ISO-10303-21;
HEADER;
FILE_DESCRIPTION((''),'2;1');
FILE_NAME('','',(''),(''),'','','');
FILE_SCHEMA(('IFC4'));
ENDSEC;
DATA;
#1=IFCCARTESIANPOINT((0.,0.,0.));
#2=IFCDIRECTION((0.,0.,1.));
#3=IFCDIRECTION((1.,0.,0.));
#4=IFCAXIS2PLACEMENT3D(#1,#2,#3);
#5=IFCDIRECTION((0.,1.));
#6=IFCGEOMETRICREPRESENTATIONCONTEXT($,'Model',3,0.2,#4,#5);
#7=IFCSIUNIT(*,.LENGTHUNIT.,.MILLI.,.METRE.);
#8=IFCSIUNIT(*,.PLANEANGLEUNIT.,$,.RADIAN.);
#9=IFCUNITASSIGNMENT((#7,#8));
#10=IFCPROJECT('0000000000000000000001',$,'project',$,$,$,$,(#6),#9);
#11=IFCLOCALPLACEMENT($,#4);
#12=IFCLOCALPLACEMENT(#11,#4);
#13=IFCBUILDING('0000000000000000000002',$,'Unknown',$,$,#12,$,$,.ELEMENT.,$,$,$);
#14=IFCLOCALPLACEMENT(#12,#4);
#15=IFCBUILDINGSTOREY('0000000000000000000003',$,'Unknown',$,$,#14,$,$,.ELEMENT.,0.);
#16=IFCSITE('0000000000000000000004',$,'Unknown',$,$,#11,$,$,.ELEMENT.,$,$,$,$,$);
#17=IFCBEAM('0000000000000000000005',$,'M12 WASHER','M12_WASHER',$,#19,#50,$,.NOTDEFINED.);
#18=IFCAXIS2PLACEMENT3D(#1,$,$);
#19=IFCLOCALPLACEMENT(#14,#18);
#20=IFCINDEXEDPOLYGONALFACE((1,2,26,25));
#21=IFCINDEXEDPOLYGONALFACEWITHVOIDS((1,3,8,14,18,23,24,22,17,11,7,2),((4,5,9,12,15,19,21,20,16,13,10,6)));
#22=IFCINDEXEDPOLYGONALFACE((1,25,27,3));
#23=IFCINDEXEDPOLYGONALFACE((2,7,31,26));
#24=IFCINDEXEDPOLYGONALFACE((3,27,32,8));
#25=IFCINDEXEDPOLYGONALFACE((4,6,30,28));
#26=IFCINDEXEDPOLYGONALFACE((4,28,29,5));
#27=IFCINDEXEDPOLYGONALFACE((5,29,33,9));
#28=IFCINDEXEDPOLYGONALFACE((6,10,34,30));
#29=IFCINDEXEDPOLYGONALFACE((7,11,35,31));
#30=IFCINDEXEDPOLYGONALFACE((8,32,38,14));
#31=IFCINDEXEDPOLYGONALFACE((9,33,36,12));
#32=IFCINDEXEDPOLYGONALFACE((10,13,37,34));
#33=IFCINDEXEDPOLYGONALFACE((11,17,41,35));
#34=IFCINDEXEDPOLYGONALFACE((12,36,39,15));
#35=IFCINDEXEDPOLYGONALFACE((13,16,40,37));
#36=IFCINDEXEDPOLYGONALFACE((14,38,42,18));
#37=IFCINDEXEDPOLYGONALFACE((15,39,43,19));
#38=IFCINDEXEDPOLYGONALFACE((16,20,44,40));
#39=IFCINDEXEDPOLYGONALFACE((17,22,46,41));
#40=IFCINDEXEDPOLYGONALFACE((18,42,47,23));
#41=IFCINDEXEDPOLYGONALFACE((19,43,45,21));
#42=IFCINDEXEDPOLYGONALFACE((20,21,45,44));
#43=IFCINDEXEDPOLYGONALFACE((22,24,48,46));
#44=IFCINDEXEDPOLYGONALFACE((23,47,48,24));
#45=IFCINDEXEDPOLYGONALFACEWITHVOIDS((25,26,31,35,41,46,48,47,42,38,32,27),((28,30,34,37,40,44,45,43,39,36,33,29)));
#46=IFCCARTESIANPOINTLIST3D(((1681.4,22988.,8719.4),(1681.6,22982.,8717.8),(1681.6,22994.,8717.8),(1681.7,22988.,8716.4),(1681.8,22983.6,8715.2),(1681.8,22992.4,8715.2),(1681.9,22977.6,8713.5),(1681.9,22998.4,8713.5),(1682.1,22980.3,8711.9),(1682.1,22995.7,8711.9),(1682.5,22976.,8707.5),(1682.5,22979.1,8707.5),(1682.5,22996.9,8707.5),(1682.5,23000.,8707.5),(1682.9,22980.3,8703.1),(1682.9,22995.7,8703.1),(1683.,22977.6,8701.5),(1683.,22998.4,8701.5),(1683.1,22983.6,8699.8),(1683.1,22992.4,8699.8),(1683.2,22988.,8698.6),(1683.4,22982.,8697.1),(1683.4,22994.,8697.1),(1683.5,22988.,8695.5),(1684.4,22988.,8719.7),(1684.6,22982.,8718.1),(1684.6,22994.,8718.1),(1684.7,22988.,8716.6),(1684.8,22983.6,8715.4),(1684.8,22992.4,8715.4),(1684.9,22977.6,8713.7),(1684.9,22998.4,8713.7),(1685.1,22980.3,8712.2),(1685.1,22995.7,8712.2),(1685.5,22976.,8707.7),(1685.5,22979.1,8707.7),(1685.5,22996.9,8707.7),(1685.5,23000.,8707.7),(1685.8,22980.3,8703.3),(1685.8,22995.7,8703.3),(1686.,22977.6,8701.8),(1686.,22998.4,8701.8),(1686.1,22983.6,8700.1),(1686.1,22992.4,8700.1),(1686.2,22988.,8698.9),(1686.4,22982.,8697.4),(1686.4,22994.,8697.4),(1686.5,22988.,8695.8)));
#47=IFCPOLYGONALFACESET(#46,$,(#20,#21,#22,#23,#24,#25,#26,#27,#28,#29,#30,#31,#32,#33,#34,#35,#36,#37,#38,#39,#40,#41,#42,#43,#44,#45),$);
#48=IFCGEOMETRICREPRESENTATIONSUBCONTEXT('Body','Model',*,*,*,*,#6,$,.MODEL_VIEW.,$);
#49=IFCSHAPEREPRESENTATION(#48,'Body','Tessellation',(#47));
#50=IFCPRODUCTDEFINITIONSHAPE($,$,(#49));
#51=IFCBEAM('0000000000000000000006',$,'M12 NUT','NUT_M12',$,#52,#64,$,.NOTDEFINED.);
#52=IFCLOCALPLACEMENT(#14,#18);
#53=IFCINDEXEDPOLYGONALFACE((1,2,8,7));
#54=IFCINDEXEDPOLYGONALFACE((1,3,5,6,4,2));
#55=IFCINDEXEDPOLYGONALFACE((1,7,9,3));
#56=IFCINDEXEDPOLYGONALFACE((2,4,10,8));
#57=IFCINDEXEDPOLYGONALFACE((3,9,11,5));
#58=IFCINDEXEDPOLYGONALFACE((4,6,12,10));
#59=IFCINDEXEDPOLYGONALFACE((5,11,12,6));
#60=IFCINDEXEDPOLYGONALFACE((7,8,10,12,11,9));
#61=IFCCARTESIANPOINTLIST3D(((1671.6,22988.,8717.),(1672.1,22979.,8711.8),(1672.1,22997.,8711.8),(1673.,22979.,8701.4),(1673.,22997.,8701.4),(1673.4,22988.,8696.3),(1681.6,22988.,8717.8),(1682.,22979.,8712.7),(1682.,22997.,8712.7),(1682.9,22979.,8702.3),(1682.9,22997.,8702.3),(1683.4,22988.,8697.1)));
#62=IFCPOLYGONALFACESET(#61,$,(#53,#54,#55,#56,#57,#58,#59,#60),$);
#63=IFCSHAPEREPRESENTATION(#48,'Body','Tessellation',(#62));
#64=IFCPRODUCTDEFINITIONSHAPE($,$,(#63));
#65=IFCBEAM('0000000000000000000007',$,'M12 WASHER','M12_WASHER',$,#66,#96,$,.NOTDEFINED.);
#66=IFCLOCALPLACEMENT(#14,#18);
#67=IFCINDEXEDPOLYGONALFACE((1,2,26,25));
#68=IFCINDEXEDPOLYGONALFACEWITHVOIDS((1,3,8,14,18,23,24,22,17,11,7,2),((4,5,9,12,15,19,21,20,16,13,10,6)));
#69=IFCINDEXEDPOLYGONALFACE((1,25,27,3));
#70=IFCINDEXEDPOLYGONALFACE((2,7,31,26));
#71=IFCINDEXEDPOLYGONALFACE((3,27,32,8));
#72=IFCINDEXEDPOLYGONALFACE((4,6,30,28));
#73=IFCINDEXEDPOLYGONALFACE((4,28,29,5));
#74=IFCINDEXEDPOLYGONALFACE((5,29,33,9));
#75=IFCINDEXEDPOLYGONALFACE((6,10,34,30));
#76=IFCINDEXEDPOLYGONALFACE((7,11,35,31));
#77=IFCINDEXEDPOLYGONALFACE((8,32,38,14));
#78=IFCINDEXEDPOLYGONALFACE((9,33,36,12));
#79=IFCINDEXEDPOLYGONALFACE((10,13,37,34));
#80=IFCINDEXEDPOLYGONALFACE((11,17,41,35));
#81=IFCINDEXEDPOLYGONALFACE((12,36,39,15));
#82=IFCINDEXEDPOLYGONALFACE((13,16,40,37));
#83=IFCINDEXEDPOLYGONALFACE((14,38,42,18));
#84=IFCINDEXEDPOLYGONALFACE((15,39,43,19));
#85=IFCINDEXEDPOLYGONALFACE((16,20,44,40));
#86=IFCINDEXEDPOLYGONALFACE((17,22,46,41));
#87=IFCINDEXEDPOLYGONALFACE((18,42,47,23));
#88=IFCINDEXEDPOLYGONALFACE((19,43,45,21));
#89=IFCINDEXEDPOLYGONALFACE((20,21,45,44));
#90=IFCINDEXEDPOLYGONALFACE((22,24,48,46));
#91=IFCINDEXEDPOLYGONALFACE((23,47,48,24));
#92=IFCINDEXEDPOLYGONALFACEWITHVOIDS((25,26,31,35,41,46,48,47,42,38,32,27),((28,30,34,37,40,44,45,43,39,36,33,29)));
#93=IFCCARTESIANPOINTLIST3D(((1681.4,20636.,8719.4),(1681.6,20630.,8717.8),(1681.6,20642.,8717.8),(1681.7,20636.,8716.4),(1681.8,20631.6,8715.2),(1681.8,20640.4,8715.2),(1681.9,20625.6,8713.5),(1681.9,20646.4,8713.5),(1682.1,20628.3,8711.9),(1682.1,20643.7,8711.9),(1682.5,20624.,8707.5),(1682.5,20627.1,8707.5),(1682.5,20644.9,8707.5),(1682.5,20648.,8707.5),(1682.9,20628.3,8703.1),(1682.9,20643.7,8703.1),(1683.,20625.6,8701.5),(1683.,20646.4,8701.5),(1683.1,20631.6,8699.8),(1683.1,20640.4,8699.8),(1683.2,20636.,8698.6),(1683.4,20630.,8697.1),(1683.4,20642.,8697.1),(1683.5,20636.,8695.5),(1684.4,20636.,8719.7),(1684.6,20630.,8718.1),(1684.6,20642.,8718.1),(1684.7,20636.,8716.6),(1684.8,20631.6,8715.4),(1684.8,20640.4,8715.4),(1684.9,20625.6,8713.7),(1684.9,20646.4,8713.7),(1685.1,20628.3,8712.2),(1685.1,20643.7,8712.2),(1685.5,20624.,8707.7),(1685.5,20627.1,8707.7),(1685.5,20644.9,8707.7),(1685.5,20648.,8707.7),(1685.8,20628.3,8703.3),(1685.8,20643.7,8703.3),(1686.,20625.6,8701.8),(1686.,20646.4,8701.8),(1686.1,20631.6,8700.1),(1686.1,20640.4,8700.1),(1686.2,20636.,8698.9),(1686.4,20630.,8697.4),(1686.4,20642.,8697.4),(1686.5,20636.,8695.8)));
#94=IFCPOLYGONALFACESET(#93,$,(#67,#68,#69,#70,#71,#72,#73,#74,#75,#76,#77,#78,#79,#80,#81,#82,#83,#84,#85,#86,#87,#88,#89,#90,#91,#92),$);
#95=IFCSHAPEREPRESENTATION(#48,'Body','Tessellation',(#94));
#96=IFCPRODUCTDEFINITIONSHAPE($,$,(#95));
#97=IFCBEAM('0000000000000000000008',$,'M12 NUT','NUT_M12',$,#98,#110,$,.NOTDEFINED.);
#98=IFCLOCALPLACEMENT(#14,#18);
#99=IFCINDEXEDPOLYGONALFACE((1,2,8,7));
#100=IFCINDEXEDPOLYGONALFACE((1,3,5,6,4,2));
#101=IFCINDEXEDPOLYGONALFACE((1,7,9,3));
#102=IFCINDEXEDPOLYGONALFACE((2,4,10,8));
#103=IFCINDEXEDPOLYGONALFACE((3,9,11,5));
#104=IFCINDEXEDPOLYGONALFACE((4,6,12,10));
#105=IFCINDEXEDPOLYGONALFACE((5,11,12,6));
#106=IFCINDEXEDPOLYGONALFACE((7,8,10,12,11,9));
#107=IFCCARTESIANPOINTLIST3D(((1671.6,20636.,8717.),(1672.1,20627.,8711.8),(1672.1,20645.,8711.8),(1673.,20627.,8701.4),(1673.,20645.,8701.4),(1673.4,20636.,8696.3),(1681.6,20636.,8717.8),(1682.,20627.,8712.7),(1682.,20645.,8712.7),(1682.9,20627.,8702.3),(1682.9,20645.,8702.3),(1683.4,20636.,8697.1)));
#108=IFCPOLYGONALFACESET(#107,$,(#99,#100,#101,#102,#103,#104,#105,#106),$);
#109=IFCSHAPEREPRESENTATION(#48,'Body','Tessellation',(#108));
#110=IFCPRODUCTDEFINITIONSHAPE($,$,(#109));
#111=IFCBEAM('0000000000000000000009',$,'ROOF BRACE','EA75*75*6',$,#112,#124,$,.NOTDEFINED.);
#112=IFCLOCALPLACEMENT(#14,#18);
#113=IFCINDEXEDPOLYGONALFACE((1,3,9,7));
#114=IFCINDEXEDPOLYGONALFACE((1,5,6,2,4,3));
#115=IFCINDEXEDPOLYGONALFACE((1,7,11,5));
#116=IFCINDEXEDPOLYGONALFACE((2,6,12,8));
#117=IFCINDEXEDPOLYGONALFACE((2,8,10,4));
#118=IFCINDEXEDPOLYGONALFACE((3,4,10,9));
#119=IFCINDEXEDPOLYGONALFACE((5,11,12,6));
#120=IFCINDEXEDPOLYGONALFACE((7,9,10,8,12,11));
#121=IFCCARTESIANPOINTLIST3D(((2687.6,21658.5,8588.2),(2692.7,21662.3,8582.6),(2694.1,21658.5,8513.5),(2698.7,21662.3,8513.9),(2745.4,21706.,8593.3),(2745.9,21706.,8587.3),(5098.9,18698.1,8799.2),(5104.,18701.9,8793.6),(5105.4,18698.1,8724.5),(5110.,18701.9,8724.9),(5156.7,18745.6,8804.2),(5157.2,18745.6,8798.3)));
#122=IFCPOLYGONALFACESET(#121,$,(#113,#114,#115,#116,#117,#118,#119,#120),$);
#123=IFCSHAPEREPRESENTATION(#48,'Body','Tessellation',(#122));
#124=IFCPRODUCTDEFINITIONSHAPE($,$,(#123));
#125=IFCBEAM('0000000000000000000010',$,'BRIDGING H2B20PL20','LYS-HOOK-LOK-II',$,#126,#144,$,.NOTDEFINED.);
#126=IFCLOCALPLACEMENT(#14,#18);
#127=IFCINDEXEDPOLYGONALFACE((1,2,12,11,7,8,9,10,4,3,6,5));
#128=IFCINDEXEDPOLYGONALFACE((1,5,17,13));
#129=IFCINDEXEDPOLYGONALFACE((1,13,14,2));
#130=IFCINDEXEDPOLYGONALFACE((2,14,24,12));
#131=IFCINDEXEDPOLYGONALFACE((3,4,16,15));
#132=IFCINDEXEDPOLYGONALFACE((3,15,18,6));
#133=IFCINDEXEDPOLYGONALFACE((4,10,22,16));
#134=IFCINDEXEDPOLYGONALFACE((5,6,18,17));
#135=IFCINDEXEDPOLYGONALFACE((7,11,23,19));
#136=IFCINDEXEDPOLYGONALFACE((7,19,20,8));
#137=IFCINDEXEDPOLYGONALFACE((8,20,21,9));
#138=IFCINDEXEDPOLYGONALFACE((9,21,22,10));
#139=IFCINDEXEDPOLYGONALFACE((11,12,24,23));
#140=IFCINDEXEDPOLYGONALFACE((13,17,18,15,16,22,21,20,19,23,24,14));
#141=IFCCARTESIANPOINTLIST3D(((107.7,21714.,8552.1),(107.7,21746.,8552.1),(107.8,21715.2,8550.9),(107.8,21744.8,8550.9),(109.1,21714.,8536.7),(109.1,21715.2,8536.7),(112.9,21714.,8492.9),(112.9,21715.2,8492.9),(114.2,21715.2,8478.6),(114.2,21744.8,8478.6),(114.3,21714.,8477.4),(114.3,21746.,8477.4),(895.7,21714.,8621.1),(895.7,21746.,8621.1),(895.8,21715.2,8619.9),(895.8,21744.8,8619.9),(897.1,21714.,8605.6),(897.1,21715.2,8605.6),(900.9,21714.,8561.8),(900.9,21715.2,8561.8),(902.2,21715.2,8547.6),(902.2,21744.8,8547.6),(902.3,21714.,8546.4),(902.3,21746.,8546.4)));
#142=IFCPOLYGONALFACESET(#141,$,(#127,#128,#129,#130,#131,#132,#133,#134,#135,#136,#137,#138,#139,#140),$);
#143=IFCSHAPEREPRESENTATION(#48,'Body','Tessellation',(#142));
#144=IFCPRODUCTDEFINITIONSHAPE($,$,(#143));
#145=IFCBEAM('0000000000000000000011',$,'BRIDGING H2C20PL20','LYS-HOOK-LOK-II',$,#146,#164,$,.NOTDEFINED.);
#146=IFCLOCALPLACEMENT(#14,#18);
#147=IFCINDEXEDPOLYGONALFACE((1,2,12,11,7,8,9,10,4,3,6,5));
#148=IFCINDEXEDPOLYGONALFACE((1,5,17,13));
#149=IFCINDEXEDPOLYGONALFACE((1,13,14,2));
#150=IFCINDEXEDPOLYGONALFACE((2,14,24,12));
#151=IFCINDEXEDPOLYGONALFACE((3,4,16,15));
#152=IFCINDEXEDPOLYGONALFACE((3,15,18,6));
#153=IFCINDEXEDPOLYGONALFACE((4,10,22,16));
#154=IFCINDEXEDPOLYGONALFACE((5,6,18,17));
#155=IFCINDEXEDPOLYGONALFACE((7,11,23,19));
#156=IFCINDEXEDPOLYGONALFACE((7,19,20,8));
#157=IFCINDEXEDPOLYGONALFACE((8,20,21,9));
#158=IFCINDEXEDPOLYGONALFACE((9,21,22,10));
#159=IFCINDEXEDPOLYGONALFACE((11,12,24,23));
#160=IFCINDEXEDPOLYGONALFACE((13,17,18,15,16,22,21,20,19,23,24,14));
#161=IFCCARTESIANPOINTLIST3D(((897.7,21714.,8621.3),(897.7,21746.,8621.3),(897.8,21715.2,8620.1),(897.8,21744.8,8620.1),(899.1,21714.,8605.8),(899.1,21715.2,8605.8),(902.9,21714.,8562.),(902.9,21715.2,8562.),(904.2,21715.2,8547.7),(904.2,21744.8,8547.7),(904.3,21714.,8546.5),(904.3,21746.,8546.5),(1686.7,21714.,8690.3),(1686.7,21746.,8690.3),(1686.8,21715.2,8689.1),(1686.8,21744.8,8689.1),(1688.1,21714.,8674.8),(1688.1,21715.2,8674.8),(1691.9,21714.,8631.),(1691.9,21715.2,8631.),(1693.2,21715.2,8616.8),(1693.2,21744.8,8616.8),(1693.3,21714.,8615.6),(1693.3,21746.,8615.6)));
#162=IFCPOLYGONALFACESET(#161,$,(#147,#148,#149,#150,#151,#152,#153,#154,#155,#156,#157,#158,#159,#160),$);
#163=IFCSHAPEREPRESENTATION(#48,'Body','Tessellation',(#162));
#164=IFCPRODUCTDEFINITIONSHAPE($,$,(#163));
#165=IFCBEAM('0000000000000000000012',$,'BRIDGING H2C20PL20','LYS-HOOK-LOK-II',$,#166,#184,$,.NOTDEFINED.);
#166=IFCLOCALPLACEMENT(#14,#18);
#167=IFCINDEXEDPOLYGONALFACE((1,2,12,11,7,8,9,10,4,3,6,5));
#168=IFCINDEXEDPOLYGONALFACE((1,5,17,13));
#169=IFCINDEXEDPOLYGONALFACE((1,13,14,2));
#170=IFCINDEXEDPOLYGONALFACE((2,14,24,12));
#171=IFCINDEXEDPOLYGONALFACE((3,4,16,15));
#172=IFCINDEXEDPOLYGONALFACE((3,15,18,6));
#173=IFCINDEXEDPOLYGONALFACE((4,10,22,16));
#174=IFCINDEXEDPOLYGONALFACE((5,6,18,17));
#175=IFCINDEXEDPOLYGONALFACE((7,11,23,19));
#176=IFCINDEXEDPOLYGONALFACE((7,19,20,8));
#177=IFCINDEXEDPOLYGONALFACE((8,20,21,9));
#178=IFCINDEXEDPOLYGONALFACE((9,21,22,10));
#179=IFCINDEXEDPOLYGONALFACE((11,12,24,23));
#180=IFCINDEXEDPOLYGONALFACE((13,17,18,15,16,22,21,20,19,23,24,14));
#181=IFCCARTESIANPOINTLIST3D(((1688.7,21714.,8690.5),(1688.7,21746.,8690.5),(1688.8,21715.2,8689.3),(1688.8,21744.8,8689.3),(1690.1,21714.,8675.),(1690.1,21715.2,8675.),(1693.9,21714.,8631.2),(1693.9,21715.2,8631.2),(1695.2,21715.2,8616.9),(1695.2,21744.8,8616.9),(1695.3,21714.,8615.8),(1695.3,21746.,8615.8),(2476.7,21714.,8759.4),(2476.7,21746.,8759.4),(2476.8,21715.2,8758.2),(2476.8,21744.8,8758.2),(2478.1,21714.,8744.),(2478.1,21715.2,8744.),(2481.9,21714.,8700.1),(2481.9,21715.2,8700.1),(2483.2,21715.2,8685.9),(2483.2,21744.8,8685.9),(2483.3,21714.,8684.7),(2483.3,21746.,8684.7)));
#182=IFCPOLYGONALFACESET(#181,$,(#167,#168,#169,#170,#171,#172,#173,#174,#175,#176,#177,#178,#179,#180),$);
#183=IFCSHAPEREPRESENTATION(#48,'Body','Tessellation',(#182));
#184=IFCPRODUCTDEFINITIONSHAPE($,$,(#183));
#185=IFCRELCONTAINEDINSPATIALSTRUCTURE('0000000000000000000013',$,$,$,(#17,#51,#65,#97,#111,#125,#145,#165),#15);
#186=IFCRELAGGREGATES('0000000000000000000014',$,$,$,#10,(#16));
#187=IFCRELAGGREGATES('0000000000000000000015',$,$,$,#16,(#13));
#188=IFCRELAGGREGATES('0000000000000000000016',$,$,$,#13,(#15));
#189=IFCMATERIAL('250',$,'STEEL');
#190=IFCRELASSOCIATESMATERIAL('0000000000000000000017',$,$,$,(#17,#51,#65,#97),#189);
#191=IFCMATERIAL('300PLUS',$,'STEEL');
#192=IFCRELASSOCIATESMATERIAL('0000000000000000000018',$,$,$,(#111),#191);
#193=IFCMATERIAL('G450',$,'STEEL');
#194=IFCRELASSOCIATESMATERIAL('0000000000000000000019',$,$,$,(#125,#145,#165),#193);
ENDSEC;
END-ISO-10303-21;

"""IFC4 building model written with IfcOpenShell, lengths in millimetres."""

from ifc_helpers import new_model, si_unit, direction, frame, origin_with_axes, place, context, subcontext, project, spatial, line, indexed_curve, outline, extrude, material, element, save


model = new_model("IFC4")

# Units and contexts
model_context = context("Model", 3, precision=0.2, world=origin_with_axes(), true_north=direction((0.0, 1.0)))
body_context = subcontext(model_context, "Body", "Model", "MODEL_VIEW")
ifc_project = project(units=[si_unit("LENGTHUNIT", "METRE", prefix="MILLI"), si_unit("PLANEANGLEUNIT", "RADIAN")], contexts=[model_context])

# Site, building, storey
site_placement = place(None, origin_with_axes())
site = spatial("IfcSite", under=ifc_project, at=site_placement, Name="Unknown", CompositionType="ELEMENT")
building_placement = place(site_placement, origin_with_axes())
building = spatial("IfcBuilding", under=site, at=building_placement, Name="Unknown", CompositionType="ELEMENT")
storey_placement = place(building_placement, origin_with_axes())
storey = spatial("IfcBuildingStorey", under=building, at=storey_placement, Name="Unknown", CompositionType="ELEMENT", Elevation=0.0)

# Beams
ifc_material_1 = material(Name="250", Category="STEEL")
beam_1_placement = place(storey_placement, frame((1685.5, 22988.0, 8707.7), z_axis=(-0.087156, 0.0, 0.996195), x_axis=(-0.996195, 0.0, -0.087156)))
element("IfcBeam", 1, at=beam_1_placement, inside=storey, material=ifc_material_1, Name="M12 WASHER", Description="M12_WASHER", PredefinedType="NOTDEFINED", context=body_context, shape_type="SolidModel", body=[
    extrude(outline(indexed_curve([(12.0, 0.0), (10.4, 6.0), (6.0, 10.4), (0.0, 12.0), (-6.0, 10.4), (-10.4, 6.0), (-12.0, 0.0), (-10.4, -6.0), (-6.0, -10.4), (0.0, -12.0), (6.0, -10.4), (10.4, -6.0)], segments=[line(1, 2, 3, 4, 5, 6, 7, 8, 9, 10, 11, 12, 1)]), holes=[indexed_curve([(8.9, 0.0), (7.7, -4.5), (4.5, -7.7), (0.0, -8.9), (-4.5, -7.7), (-7.7, -4.5), (-8.9, 0.0), (-7.7, 4.5), (-4.5, 7.7), (0.0, 8.9), (4.5, 7.7), (7.7, 4.5)], segments=[line(1, 2, 3, 4, 5, 6, 7, 8, 9, 10, 11, 12, 1)])]), frame((0.0, 0.0, 0.0), z_axis=(-1.0, 0.0, 0.0), x_axis=(0.0, 0.0, 1.0)), (0.0, 0.0, -1.0), 3.0),
])
beam_2_placement = place(storey_placement, frame((1682.5, 22988.0, 8707.5), z_axis=(-0.087156, 0.0, 0.996195), x_axis=(-0.996195, 0.0, -0.087156)))
element("IfcBeam", 2, at=beam_2_placement, inside=storey, material=ifc_material_1, Name="M12 NUT", Description="NUT_M12", PredefinedType="NOTDEFINED", context=body_context, shape_type="SolidModel", body=[
    extrude(outline(indexed_curve([(5.2, -9.0), (10.4, 0.0), (5.2, 9.0), (-5.2, 9.0), (-10.4, 0.0), (-5.2, -9.0)], segments=[line(1, 2, 3, 4, 5, 6, 1)])), frame((0.0, 0.0, 0.0), z_axis=(-1.0, 0.0, 0.0), x_axis=(0.0, 0.0, 1.0)), (0.0, 0.0, -1.0), 10.0),
])
beam_3_placement = place(storey_placement, frame((1685.5, 20636.0, 8707.7), z_axis=(-0.087156, 0.0, 0.996195), x_axis=(-0.996195, 0.0, -0.087156)))
element("IfcBeam", 3, at=beam_3_placement, inside=storey, material=ifc_material_1, Name="M12 WASHER", Description="M12_WASHER", PredefinedType="NOTDEFINED", context=body_context, shape_type="SolidModel", body=[
    extrude(outline(indexed_curve([(12.0, 0.0), (10.4, 6.0), (6.0, 10.4), (0.0, 12.0), (-6.0, 10.4), (-10.4, 6.0), (-12.0, 0.0), (-10.4, -6.0), (-6.0, -10.4), (0.0, -12.0), (6.0, -10.4), (10.4, -6.0)], segments=[line(1, 2, 3, 4, 5, 6, 7, 8, 9, 10, 11, 12, 1)]), holes=[indexed_curve([(8.9, 0.0), (7.7, -4.5), (4.5, -7.7), (0.0, -8.9), (-4.5, -7.7), (-7.7, -4.5), (-8.9, 0.0), (-7.7, 4.5), (-4.5, 7.7), (0.0, 8.9), (4.5, 7.7), (7.7, 4.5)], segments=[line(1, 2, 3, 4, 5, 6, 7, 8, 9, 10, 11, 12, 1)])]), frame((0.0, 0.0, 0.0), z_axis=(-1.0, 0.0, 0.0), x_axis=(0.0, 0.0, 1.0)), (0.0, 0.0, -1.0), 3.0),
])
beam_4_placement = place(storey_placement, frame((1682.5, 20636.0, 8707.5), z_axis=(-0.087156, 0.0, 0.996195), x_axis=(-0.996195, 0.0, -0.087156)))
element("IfcBeam", 4, at=beam_4_placement, inside=storey, material=ifc_material_1, Name="M12 NUT", Description="NUT_M12", PredefinedType="NOTDEFINED", context=body_context, shape_type="SolidModel", body=[
    extrude(outline(indexed_curve([(5.2, -9.0), (10.4, 0.0), (5.2, 9.0), (-5.2, 9.0), (-10.4, 0.0), (-5.2, -9.0)], segments=[line(1, 2, 3, 4, 5, 6, 1)])), frame((0.0, 0.0, 0.0), z_axis=(-1.0, 0.0, 0.0), x_axis=(0.0, 0.0, 1.0)), (0.0, 0.0, -1.0), 10.0),
])
ifc_material_2 = material(Name="300PLUS", Category="STEEL")
beam_5_placement = place(storey_placement, frame((2719.7, 21682.3, 8553.4), z_axis=(0.771221, 0.632983, 0.067458), x_axis=(0.630574, -0.774166, 0.055173)))
element("IfcBeam", 5, at=beam_5_placement, inside=storey, material=ifc_material_2, Name="ROOF BRACE", Description="EA75*75*6", PredefinedType="NOTDEFINED", context=body_context, shape_type="SolidModel", body=[
    extrude(outline(indexed_curve([(-37.5, -37.5), (37.5, -37.5), (37.5, -31.5), (-31.5, -31.5), (-31.5, 37.5), (-37.5, 37.5)], segments=[line(1, 2, 3, 4, 5, 6, 1)])), frame((0.0, 0.0, 0.0), z_axis=(-1.0, 0.0, 0.0), x_axis=(0.0, 0.0, 1.0)), (0.0, 0.0, -1.0), 3824.0),
])
ifc_material_3 = material(Name="G450", Category="STEEL")
beam_6_placement = place(storey_placement, frame((111.0, 21730.0, 8514.8), z_axis=(0.0, -1.0, 0.0), x_axis=(0.996194, 0.0, 0.087159)))
element("IfcBeam", 6, at=beam_6_placement, inside=storey, material=ifc_material_3, Name="BRIDGING H2B20PL20", Description="LYS-HOOK-LOK-II", PredefinedType="NOTDEFINED", context=body_context, shape_type="SolidModel", body=[
    extrude(outline(indexed_curve([(16.0, -37.5), (16.0, -22.0), (14.8, -22.0), (14.8, -36.3), (-14.8, -36.3), (-14.8, 36.3), (14.8, 36.3), (14.8, 22.0), (16.0, 22.0), (16.0, 37.5), (-16.0, 37.5), (-16.0, -37.5)], segments=[line(1, 2, 3, 4, 5, 6, 7, 8, 9, 10, 11, 12, 1)])), frame((0.0, 0.0, 0.0), z_axis=(-1.0, 0.0, 0.0), x_axis=(0.0, 0.0, 1.0)), (0.0, 0.0, -1.0), 791.0),
])
beam_7_placement = place(storey_placement, frame((901.0, 21730.0, 8583.9), z_axis=(0.0, -1.0, 0.0), x_axis=(0.996195, 0.0, 0.087155)))
element("IfcBeam", 7, at=beam_7_placement, inside=storey, material=ifc_material_3, Name="BRIDGING H2C20PL20", Description="LYS-HOOK-LOK-II", PredefinedType="NOTDEFINED", context=body_context, shape_type="SolidModel", body=[
    extrude(outline(indexed_curve([(16.0, -37.5), (16.0, -22.0), (14.8, -22.0), (14.8, -36.3), (-14.8, -36.3), (-14.8, 36.3), (14.8, 36.3), (14.8, 22.0), (16.0, 22.0), (16.0, 37.5), (-16.0, 37.5), (-16.0, -37.5)], segments=[line(1, 2, 3, 4, 5, 6, 7, 8, 9, 10, 11, 12, 1)])), frame((0.0, 0.0, 0.0), z_axis=(-1.0, 0.0, 0.0), x_axis=(0.0, 0.0, 1.0)), (0.0, 0.0, -1.0), 792.0),
])
beam_8_placement = place(storey_placement, frame((1692.0, 21730.0, 8653.1), z_axis=(0.0, -1.0, 0.0), x_axis=(0.996194, 0.0, 0.087159)))
element("IfcBeam", 8, at=beam_8_placement, inside=storey, material=ifc_material_3, Name="BRIDGING H2C20PL20", Description="LYS-HOOK-LOK-II", PredefinedType="NOTDEFINED", context=body_context, shape_type="SolidModel", body=[
    extrude(outline(indexed_curve([(16.0, -37.5), (16.0, -22.0), (14.8, -22.0), (14.8, -36.3), (-14.8, -36.3), (-14.8, 36.3), (14.8, 36.3), (14.8, 22.0), (16.0, 22.0), (16.0, 37.5), (-16.0, 37.5), (-16.0, -37.5)], segments=[line(1, 2, 3, 4, 5, 6, 7, 8, 9, 10, 11, 12, 1)])), frame((0.0, 0.0, 0.0), z_axis=(-1.0, 0.0, 0.0), x_axis=(0.0, 0.0, 1.0)), (0.0, 0.0, -1.0), 791.0),
])

save(model, "model.ifc")
